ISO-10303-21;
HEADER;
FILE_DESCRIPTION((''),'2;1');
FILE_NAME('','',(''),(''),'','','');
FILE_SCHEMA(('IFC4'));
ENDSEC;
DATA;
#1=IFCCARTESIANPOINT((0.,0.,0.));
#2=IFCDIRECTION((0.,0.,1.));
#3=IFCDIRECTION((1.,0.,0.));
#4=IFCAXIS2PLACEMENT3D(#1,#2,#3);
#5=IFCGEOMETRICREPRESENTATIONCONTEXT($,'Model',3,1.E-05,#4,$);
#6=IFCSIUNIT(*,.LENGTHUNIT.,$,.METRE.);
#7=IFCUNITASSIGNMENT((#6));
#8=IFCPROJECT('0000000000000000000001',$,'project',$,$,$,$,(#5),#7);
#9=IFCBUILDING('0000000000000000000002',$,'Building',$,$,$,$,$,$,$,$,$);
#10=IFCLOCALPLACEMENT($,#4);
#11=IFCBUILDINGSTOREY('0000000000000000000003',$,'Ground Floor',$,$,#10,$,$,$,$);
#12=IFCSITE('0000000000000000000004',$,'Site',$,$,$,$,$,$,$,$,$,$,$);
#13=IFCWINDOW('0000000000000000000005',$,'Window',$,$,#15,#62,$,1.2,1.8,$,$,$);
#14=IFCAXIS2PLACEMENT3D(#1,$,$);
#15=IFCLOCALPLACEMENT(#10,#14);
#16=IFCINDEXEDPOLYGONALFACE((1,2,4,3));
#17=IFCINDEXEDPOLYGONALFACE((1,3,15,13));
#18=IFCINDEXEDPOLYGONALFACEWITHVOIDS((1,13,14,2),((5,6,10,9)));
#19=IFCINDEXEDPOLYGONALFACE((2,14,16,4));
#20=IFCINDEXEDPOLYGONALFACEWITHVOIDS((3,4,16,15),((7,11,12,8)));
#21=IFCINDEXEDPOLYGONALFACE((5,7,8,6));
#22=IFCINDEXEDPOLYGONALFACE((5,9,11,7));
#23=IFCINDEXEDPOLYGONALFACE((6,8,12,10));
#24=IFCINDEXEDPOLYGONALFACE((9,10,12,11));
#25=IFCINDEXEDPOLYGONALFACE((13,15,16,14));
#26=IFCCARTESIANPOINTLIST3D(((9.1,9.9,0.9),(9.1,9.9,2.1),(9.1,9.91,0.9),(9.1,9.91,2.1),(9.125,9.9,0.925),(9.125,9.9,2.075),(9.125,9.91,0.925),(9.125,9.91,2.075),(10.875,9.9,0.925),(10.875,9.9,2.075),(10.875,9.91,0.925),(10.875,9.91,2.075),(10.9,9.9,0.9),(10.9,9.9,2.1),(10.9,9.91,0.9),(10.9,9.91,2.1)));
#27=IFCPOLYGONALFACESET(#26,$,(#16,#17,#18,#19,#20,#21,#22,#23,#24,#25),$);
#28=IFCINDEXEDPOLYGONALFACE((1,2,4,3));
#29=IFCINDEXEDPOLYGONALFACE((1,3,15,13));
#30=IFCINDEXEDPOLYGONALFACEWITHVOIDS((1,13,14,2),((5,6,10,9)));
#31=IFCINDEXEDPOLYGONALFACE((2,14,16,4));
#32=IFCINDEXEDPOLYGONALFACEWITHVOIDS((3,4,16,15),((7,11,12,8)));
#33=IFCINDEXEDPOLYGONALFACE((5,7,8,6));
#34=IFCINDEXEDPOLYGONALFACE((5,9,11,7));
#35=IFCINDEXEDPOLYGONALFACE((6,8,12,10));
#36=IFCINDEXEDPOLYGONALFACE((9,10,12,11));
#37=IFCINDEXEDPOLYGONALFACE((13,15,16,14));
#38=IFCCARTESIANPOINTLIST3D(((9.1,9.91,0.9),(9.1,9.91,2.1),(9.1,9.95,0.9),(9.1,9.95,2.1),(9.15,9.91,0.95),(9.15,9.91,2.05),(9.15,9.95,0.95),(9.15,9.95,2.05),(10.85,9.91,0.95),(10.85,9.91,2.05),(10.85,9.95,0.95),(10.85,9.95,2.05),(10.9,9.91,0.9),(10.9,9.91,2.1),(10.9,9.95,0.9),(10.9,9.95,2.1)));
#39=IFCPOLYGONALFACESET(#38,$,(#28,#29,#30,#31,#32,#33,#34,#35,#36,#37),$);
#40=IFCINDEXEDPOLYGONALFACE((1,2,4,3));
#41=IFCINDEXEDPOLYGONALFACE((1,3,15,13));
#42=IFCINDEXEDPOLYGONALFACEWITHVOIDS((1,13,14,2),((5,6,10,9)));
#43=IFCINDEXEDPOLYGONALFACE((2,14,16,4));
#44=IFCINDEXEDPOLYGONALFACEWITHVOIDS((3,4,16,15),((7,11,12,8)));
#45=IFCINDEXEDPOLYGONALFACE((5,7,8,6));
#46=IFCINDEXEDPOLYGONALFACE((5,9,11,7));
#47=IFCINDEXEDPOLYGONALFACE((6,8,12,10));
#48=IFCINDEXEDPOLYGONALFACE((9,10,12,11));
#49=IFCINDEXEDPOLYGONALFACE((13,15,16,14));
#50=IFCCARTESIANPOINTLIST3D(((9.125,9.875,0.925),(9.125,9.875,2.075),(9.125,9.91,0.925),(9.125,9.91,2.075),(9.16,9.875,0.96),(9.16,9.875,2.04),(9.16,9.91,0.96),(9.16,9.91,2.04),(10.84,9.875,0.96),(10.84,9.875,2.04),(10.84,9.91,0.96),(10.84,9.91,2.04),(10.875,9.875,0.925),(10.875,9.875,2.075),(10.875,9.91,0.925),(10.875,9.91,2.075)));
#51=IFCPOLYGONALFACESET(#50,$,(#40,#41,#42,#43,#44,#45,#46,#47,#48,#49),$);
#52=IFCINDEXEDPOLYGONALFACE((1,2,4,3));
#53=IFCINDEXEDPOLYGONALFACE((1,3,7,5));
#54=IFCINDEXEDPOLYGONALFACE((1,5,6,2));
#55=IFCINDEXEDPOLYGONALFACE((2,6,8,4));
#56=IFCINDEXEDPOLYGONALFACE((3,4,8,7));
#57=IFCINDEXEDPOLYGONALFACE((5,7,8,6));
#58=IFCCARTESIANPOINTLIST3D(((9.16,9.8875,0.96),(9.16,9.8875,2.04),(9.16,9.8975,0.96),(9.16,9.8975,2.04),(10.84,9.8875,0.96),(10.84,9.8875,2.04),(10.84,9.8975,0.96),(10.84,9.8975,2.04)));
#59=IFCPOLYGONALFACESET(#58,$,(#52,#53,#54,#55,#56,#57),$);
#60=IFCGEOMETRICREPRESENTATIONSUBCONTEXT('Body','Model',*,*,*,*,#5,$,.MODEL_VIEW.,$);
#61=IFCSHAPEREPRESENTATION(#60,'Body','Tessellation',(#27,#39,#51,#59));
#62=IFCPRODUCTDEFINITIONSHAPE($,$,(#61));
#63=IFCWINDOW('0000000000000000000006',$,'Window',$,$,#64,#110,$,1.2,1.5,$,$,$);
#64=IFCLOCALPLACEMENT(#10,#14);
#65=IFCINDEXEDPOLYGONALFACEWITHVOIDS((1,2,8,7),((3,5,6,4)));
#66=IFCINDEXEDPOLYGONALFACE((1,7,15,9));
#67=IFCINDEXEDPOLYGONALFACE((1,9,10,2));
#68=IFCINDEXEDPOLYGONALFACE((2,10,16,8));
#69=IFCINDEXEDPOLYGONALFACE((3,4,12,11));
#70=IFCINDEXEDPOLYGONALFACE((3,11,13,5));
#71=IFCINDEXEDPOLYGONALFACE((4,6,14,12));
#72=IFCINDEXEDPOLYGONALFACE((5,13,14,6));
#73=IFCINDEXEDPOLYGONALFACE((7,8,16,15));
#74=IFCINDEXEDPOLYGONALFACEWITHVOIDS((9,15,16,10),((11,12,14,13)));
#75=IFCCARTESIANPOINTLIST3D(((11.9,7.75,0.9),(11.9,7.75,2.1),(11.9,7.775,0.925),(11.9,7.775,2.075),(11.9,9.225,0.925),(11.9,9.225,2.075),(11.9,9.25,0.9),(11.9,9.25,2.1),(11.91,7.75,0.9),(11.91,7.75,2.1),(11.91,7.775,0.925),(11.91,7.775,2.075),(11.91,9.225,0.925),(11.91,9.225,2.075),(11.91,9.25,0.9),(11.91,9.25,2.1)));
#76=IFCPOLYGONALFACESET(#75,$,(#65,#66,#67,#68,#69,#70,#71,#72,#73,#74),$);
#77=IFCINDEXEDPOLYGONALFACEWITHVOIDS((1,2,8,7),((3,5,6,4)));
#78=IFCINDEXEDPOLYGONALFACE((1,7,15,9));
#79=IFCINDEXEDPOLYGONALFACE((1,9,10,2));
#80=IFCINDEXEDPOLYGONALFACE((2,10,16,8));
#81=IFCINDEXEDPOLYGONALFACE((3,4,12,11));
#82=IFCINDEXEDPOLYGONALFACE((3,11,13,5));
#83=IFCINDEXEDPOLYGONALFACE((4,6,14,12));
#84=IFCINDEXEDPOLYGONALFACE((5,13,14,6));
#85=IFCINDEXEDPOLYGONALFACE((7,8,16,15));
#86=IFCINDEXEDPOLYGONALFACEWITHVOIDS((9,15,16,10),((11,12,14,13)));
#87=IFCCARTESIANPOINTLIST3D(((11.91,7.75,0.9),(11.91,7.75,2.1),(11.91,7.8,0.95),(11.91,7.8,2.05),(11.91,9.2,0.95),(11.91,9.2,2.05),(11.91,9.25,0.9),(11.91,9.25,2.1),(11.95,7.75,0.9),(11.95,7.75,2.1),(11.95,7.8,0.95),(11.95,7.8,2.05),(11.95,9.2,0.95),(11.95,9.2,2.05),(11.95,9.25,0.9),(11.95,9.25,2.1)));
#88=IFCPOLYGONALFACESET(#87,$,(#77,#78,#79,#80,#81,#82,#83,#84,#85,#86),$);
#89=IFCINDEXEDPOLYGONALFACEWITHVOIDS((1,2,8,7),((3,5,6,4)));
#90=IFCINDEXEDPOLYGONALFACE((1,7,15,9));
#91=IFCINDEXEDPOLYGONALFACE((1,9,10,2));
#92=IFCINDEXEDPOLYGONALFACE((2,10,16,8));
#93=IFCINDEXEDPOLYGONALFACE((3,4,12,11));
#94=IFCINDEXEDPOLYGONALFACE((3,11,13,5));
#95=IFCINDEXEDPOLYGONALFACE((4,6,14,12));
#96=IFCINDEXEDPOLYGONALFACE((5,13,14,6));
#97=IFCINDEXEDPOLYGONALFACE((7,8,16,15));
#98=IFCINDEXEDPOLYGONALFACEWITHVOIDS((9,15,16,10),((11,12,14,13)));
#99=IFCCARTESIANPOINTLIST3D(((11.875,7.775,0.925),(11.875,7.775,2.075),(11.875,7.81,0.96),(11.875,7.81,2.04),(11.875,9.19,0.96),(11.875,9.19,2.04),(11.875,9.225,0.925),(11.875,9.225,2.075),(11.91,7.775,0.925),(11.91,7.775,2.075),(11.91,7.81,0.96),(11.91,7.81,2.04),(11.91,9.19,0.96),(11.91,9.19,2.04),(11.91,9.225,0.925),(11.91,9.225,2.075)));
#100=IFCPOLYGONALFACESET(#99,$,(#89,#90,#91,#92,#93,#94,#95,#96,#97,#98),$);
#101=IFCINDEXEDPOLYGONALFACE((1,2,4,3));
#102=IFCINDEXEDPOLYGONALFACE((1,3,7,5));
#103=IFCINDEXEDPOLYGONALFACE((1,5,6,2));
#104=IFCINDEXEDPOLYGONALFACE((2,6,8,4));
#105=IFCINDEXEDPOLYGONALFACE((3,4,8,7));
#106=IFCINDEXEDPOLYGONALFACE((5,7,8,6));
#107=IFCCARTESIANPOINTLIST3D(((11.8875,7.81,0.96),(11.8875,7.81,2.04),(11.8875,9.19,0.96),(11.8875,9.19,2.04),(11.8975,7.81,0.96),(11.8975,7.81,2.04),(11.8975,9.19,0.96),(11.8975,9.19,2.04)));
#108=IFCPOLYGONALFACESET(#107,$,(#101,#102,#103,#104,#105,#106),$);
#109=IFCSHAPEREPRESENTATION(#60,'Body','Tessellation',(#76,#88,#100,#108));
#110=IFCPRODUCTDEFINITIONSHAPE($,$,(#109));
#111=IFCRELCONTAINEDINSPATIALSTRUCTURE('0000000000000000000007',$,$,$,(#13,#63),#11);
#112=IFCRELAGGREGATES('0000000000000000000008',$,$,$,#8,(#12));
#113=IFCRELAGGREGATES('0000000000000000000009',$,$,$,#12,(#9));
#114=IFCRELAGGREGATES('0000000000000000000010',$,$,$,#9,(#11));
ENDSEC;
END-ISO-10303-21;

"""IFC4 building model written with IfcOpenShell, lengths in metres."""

from ifc_helpers import new_model, si_unit, frame, origin_with_axes, place, context, subcontext, project, spatial, line, indexed_curve, outline, extrude, element, save


model = new_model("IFC4")

# Units and contexts
model_context = context("Model", 3, precision=1e-05, world=origin_with_axes())
body_context = subcontext(model_context, "Body", "Model", "MODEL_VIEW")
ifc_project = project(units=[si_unit("LENGTHUNIT", "METRE")], contexts=[model_context])

# Site, building, storey
site = spatial("IfcSite", under=ifc_project, Name="Site")
building = spatial("IfcBuilding", under=site, Name="Building")
storey_placement = place(None, origin_with_axes())
storey = spatial("IfcBuildingStorey", under=building, at=storey_placement, Name="Ground Floor")

# Windows
window_1_placement = place(storey_placement, frame((10.9, 10.0, 0.9), z_axis=(0.0, 0.0, 1.0), x_axis=(-1.0, 0.0, 0.0)))
element("IfcWindow", 1, at=window_1_placement, inside=storey, Name="Window", OverallHeight=1.2, OverallWidth=1.8, context=body_context, shape_type="SweptSolid", body=[
    extrude(outline(indexed_curve([(0.0, 0.0), (1.8, 0.0), (1.8, 1.2), (0.0, 1.2)], segments=[line(1, 2, 3, 4, 1)]), holes=[indexed_curve([(0.025, 0.025), (1.775, 0.025), (1.775, 1.175), (0.025, 1.175)], segments=[line(1, 2, 3, 4, 1)])]), frame((0.0, 0.09, 0.0), z_axis=(0.0, -1.0, 0.0), x_axis=(1.0, 0.0, 0.0)), (0.0, 0.0, -1.0), 0.01),
    extrude(outline(indexed_curve([(0.0, 0.0), (1.8, 0.0), (1.8, 1.2), (0.0, 1.2)], segments=[line(1, 2, 3, 4, 1)]), holes=[indexed_curve([(0.05, 0.05), (1.75, 0.05), (1.75, 1.15), (0.05, 1.15)], segments=[line(1, 2, 3, 4, 1)])]), frame((0.0, 0.05, 0.0), z_axis=(0.0, -1.0, 0.0), x_axis=(1.0, 0.0, 0.0)), (0.0, 0.0, -1.0), 0.04),
    extrude(outline(indexed_curve([(0.0, 0.0), (1.75, 0.0), (1.75, 1.15), (0.0, 1.15)], segments=[line(1, 2, 3, 4, 1)]), holes=[indexed_curve([(0.035, 0.035), (1.715, 0.035), (1.715, 1.115), (0.035, 1.115)], segments=[line(1, 2, 3, 4, 1)])]), frame((0.025, 0.09, 0.025), z_axis=(0.0, -1.0, 0.0), x_axis=(1.0, 0.0, 0.0)), (0.0, 0.0, -1.0), 0.035),
    extrude(outline(indexed_curve([(0.035, 0.035), (1.715, 0.035), (1.715, 1.115), (0.035, 1.115)], segments=[line(1, 2, 3, 4, 1)])), frame((0.025, 0.1025, 0.025), z_axis=(0.0, -1.0, 0.0), x_axis=(1.0, 0.0, 0.0)), (0.0, 0.0, -1.0), 0.01),
])
window_2_placement = place(storey_placement, frame((12.0, 7.75, 0.9), z_axis=(0.0, 0.0, 1.0), x_axis=(0.0, 1.0, 0.0)))
element("IfcWindow", 2, at=window_2_placement, inside=storey, Name="Window", OverallHeight=1.2, OverallWidth=1.5, context=body_context, shape_type="SweptSolid", body=[
    extrude(outline(indexed_curve([(0.0, 0.0), (1.5, 0.0), (1.5, 1.2), (0.0, 1.2)], segments=[line(1, 2, 3, 4, 1)]), holes=[indexed_curve([(0.025, 0.025), (1.475, 0.025), (1.475, 1.175), (0.025, 1.175)], segments=[line(1, 2, 3, 4, 1)])]), frame((0.0, 0.09, 0.0), z_axis=(0.0, -1.0, 0.0), x_axis=(1.0, 0.0, 0.0)), (0.0, 0.0, -1.0), 0.01),
    extrude(outline(indexed_curve([(0.0, 0.0), (1.5, 0.0), (1.5, 1.2), (0.0, 1.2)], segments=[line(1, 2, 3, 4, 1)]), holes=[indexed_curve([(0.05, 0.05), (1.45, 0.05), (1.45, 1.15), (0.05, 1.15)], segments=[line(1, 2, 3, 4, 1)])]), frame((0.0, 0.05, 0.0), z_axis=(0.0, -1.0, 0.0), x_axis=(1.0, 0.0, 0.0)), (0.0, 0.0, -1.0), 0.04),
    extrude(outline(indexed_curve([(0.0, 0.0), (1.45, 0.0), (1.45, 1.15), (0.0, 1.15)], segments=[line(1, 2, 3, 4, 1)]), holes=[indexed_curve([(0.035, 0.035), (1.415, 0.035), (1.415, 1.115), (0.035, 1.115)], segments=[line(1, 2, 3, 4, 1)])]), frame((0.025, 0.09, 0.025), z_axis=(0.0, -1.0, 0.0), x_axis=(1.0, 0.0, 0.0)), (0.0, 0.0, -1.0), 0.035),
    extrude(outline(indexed_curve([(0.035, 0.035), (1.415, 0.035), (1.415, 1.115), (0.035, 1.115)], segments=[line(1, 2, 3, 4, 1)])), frame((0.025, 0.1025, 0.025), z_axis=(0.0, -1.0, 0.0), x_axis=(1.0, 0.0, 0.0)), (0.0, 0.0, -1.0), 0.01),
])

save(model, "model.ifc")
